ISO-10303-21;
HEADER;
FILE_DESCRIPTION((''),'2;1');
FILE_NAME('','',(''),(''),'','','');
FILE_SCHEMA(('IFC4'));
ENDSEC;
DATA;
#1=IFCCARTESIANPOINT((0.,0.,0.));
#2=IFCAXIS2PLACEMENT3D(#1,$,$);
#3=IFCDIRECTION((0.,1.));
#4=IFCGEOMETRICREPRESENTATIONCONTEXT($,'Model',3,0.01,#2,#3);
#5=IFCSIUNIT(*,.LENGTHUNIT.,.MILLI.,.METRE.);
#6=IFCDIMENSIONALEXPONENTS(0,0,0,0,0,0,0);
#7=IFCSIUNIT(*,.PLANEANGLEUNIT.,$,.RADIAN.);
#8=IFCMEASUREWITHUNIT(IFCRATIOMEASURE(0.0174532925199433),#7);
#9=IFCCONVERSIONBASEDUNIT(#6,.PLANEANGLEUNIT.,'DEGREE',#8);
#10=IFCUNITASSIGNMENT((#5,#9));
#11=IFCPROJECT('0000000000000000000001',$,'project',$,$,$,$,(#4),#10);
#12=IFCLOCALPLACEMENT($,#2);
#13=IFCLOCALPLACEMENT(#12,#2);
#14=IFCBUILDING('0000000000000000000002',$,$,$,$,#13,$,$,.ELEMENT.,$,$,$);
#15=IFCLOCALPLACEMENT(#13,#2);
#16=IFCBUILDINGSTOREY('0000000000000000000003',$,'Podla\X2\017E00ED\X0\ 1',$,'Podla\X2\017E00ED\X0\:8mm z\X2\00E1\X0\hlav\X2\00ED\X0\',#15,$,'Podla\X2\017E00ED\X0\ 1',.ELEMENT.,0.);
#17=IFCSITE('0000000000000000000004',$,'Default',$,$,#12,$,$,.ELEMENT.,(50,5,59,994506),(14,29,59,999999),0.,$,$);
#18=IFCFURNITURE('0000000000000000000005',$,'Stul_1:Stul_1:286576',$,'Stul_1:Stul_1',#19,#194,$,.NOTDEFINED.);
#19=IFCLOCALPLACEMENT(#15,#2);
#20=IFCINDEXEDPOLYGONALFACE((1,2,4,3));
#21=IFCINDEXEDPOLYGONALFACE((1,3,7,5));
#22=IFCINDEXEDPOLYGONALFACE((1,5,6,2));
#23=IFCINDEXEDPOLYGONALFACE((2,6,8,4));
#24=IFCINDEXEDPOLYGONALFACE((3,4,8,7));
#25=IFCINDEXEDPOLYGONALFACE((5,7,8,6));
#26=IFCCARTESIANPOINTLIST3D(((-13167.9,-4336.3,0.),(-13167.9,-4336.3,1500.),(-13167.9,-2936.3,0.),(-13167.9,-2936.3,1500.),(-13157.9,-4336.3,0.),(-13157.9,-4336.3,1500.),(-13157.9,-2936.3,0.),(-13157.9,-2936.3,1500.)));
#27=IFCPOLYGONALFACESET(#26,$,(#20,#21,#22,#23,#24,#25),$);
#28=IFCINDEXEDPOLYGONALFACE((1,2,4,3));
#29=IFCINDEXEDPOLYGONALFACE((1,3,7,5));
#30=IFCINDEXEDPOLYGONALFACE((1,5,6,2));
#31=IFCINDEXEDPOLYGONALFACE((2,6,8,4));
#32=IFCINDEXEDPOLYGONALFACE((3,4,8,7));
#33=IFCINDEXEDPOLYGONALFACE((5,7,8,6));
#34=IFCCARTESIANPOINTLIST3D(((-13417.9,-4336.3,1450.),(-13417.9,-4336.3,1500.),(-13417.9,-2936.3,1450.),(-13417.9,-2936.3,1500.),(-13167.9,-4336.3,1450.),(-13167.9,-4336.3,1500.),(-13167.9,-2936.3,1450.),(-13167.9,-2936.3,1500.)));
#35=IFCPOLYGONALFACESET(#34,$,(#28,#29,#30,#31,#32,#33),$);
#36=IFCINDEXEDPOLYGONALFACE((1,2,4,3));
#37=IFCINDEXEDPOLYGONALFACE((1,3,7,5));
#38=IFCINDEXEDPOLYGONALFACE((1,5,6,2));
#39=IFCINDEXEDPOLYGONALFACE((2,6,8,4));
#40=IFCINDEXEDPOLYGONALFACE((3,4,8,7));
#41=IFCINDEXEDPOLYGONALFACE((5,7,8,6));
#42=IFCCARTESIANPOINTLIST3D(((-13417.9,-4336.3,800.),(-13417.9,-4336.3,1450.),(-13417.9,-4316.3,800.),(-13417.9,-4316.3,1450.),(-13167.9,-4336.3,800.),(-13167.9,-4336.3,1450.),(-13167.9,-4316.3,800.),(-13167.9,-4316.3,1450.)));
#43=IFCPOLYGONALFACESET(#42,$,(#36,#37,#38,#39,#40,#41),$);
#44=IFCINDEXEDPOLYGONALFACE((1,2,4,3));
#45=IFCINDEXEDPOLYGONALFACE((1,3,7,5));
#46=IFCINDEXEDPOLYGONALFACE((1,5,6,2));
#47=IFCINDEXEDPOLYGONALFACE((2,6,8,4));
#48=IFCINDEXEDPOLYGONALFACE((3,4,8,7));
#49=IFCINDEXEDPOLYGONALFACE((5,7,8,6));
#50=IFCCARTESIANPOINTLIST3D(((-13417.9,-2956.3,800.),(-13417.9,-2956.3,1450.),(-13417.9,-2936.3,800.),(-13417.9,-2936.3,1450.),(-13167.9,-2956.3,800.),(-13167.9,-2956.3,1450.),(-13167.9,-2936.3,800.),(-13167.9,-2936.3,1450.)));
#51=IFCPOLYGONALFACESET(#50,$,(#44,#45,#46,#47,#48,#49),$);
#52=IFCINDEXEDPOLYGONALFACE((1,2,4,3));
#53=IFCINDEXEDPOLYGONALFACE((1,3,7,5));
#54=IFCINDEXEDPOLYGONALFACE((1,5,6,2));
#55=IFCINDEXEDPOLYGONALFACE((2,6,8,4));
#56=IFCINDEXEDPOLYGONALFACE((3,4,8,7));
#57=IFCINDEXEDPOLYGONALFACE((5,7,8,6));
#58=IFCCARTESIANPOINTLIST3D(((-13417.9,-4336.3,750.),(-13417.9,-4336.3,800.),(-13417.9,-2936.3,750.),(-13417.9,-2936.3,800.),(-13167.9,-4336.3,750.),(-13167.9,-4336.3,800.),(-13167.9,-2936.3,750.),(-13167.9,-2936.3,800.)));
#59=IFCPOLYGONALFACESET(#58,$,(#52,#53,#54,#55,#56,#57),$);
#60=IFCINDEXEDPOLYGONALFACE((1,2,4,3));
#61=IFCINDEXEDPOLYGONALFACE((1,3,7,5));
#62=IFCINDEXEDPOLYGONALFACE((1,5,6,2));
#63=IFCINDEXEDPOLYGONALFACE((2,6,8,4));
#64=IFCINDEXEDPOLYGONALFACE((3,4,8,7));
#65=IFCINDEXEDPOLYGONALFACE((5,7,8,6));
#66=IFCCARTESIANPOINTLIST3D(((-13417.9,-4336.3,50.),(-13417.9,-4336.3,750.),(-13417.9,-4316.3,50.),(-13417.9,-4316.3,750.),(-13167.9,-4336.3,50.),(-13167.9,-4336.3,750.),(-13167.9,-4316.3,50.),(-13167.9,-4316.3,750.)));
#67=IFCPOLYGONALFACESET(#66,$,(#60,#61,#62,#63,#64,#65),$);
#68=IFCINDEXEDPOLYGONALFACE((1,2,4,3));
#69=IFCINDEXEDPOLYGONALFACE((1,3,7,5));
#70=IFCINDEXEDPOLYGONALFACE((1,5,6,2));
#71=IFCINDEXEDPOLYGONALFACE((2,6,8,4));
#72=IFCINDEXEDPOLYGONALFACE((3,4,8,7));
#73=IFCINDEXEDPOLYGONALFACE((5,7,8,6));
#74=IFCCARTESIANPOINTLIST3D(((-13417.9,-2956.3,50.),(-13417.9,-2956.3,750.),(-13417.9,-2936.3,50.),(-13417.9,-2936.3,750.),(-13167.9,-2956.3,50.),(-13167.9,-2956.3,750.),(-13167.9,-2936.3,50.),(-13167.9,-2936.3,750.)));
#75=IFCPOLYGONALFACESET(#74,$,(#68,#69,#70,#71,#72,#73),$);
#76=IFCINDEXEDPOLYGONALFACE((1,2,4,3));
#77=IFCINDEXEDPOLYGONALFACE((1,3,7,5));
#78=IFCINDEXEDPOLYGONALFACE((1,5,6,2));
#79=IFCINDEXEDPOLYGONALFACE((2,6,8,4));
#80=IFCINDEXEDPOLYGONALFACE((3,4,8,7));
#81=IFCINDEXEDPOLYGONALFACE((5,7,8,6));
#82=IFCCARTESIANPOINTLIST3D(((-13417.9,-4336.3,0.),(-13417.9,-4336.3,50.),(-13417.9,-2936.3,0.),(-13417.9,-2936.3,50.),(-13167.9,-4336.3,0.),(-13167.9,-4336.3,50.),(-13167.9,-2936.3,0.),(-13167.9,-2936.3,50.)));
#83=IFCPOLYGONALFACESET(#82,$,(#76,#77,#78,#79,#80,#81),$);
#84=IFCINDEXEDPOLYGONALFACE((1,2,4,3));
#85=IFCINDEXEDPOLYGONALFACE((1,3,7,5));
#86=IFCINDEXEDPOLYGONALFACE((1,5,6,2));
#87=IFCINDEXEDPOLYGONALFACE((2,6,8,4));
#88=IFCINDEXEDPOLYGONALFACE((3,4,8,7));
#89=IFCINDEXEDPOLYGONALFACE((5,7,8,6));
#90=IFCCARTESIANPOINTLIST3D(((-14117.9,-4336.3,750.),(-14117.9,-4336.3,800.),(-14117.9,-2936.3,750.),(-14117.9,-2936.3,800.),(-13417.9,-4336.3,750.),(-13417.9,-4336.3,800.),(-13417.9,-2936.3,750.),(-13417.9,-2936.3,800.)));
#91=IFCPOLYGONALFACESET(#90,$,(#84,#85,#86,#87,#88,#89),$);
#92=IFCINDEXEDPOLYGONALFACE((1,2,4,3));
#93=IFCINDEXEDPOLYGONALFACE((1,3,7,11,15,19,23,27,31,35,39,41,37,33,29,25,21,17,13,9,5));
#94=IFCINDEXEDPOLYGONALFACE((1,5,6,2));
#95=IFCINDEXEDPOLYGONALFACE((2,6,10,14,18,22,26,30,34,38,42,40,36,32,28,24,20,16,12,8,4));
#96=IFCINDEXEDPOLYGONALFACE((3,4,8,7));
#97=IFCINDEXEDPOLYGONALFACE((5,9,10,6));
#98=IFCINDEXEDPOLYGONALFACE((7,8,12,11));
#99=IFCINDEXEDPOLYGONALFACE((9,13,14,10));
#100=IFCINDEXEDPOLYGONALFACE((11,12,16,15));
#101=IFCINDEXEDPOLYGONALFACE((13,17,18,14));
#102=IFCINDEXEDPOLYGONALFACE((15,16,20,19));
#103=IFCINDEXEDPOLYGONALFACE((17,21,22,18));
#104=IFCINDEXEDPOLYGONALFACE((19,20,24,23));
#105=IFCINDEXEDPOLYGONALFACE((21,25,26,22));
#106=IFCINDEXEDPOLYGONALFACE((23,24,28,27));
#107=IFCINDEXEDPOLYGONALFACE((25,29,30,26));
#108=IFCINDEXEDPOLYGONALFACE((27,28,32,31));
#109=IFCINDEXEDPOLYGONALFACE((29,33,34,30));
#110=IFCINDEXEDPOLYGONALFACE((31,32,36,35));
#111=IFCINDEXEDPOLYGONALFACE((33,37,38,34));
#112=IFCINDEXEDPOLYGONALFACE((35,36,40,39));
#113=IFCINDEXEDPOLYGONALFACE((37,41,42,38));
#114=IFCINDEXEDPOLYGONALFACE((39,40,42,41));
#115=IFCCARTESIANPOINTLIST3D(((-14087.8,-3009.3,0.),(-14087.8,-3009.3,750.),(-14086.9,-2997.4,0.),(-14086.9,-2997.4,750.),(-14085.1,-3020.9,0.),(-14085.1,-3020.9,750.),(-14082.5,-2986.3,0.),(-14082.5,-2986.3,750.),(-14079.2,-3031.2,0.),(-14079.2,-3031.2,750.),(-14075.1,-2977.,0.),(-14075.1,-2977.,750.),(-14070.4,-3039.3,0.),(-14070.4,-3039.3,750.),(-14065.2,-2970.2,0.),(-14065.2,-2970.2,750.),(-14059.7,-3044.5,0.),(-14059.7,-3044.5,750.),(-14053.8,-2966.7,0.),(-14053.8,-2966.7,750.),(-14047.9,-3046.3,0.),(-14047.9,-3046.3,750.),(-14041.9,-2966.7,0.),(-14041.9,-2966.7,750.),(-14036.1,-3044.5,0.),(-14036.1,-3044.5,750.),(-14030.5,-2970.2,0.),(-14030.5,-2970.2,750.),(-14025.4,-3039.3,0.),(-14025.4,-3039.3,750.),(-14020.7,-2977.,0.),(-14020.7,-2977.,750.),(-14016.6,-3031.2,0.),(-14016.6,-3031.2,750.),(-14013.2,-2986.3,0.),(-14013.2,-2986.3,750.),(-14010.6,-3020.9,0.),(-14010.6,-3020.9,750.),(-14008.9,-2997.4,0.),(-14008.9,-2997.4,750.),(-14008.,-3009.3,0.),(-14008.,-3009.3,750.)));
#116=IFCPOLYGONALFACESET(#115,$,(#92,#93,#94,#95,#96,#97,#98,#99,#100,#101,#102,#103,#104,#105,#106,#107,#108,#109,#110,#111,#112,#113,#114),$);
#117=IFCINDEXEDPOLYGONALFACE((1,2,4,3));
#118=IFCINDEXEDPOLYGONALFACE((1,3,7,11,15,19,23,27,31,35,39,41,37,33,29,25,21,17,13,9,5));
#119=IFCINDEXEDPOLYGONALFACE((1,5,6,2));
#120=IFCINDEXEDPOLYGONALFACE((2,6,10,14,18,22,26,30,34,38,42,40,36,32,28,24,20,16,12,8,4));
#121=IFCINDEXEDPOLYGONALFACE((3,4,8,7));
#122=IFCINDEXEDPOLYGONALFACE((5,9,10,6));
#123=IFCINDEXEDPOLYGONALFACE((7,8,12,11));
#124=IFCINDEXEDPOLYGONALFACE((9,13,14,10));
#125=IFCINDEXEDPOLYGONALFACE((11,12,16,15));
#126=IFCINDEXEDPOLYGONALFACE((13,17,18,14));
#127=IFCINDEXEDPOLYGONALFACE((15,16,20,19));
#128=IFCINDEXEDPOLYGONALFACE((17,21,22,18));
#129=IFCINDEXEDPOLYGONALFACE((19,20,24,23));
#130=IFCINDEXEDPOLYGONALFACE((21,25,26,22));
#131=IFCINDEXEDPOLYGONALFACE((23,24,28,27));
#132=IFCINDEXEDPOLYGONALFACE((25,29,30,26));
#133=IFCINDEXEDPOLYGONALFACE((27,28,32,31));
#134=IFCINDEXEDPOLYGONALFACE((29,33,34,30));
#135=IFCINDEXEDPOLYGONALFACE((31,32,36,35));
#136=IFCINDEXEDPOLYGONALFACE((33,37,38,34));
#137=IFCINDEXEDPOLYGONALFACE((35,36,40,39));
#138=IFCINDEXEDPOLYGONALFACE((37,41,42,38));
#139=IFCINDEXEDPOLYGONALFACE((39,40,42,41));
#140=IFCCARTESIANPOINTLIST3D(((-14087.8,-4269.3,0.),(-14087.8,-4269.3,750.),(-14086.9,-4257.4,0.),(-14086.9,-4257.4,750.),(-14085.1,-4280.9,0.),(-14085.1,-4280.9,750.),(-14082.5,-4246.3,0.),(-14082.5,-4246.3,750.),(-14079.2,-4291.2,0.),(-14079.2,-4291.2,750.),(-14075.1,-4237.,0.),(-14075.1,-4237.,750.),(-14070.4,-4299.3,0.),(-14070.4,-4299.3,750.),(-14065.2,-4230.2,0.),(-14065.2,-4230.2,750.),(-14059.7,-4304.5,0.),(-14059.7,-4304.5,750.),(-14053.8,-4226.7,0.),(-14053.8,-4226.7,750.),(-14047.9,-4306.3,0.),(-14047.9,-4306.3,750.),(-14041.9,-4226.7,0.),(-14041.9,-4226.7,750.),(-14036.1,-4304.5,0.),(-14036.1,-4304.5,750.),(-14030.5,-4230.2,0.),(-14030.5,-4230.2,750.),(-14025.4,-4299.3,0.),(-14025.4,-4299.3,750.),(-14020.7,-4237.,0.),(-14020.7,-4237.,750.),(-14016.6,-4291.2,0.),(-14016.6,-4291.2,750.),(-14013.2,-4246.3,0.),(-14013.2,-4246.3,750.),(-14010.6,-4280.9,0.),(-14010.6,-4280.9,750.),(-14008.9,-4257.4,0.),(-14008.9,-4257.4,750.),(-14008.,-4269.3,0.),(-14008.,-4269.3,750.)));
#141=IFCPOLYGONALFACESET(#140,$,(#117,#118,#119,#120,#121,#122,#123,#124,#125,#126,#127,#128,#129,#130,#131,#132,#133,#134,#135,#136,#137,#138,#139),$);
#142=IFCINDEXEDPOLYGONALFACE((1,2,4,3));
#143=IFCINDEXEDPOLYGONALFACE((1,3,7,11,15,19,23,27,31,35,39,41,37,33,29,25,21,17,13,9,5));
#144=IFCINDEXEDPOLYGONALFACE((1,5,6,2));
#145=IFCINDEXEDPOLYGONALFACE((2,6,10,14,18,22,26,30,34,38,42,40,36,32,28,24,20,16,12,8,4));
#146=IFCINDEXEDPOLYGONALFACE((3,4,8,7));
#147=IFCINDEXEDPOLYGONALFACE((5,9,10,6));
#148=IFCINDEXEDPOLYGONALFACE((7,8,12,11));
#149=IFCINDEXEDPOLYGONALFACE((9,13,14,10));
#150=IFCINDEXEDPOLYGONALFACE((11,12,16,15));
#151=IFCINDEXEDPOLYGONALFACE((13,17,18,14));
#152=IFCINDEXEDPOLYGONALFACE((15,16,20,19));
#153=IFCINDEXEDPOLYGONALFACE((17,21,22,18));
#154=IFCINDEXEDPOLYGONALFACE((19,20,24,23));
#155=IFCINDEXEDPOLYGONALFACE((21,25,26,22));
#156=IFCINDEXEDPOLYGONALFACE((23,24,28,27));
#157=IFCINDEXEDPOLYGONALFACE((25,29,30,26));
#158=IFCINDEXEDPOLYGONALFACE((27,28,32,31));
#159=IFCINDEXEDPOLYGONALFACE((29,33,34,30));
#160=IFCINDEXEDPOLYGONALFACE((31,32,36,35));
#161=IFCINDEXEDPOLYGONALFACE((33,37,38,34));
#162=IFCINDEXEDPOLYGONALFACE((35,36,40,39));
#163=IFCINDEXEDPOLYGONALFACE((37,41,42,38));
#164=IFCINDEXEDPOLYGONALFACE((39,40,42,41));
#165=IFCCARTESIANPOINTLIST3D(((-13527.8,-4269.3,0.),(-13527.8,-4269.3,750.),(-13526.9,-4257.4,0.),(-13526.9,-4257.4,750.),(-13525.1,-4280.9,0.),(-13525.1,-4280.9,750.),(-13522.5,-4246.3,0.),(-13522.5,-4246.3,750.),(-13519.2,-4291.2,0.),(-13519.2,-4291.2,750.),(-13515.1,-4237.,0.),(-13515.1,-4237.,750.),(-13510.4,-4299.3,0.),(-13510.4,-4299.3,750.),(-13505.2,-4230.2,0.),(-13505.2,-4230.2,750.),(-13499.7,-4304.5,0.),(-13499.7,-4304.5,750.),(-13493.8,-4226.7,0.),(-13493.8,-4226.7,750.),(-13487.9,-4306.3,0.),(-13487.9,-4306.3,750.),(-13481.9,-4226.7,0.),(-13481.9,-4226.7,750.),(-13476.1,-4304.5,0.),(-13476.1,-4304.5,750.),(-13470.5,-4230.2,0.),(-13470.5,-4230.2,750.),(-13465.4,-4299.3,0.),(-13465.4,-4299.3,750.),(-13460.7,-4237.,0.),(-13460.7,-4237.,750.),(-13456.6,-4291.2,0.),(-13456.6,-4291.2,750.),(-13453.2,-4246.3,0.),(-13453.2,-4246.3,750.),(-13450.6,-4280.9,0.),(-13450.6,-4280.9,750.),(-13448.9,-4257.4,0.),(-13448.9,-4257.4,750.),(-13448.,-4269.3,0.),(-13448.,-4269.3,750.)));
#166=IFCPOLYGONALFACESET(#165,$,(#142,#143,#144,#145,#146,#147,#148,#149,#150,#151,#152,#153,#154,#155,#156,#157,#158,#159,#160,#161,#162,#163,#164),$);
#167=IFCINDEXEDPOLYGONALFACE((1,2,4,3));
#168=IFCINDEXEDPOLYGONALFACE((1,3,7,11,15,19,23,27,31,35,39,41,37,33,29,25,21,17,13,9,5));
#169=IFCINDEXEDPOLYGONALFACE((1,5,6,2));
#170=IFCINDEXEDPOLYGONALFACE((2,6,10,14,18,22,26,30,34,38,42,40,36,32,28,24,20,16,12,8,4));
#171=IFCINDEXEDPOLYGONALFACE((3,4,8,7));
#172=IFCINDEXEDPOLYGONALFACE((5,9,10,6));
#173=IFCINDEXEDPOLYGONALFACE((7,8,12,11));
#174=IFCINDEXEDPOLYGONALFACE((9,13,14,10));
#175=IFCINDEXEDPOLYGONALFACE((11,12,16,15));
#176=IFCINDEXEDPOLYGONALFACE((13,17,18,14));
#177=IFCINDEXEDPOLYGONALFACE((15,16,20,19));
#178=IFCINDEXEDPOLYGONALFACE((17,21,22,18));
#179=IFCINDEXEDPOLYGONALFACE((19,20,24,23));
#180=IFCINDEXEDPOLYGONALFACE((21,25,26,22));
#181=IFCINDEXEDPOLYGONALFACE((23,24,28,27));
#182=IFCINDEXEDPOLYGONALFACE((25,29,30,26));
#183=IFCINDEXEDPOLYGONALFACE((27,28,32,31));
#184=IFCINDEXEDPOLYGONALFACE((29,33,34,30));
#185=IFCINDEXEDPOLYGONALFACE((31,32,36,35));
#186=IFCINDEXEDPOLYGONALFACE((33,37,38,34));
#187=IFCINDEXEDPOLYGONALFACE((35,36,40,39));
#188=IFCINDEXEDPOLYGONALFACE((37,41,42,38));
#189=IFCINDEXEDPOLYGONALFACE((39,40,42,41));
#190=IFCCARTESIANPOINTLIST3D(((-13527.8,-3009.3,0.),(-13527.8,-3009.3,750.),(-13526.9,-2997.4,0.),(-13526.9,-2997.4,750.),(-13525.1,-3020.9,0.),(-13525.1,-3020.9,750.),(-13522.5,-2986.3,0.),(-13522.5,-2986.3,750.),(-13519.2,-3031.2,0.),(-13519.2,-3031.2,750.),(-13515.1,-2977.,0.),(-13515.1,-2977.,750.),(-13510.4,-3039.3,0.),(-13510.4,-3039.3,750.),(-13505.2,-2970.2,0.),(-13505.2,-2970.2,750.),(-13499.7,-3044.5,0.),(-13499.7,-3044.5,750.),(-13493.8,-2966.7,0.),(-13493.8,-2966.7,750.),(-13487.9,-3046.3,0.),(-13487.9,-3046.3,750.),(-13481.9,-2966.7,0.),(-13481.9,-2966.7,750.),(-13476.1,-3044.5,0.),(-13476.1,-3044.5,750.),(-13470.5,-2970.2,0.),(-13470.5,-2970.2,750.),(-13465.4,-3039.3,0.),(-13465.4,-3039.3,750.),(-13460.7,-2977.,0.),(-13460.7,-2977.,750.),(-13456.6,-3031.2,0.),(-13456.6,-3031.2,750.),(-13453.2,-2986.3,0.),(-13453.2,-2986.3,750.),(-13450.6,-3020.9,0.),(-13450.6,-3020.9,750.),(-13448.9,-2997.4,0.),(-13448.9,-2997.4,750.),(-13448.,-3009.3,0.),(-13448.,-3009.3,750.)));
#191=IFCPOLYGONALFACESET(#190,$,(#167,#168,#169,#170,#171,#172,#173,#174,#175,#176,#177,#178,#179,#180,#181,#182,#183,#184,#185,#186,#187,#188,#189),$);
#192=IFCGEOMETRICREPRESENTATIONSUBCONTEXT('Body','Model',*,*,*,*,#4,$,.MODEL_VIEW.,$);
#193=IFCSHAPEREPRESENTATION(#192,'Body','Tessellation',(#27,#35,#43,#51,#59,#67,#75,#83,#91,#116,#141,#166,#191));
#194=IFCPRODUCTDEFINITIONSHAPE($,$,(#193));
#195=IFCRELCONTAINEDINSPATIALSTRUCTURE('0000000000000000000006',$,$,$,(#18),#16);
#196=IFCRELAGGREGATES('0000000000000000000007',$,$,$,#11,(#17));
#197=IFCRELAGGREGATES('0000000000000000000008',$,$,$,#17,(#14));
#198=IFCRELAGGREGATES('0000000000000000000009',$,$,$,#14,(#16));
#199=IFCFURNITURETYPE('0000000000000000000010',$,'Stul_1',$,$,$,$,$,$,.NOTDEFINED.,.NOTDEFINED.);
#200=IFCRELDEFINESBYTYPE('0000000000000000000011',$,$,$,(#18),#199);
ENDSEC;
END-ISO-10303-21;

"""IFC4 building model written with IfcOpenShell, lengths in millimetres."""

from ifc_helpers import new_model, entity, si_unit, converted_unit, direction, frame, frame_2d, origin, origin_2d_with_axis, place, context, subcontext, project, spatial, rectangle, circle, extrude, source, transform, mapped, type_object, type_shapes, element, save


model = new_model("IFC4")

# Units and contexts
model_context = context("Model", 3, precision=0.01, world=origin(), true_north=direction((0.0, 1.0)))
body_context = subcontext(model_context, "Body", "Model", "MODEL_VIEW")
ifc_project = project(units=[si_unit("LENGTHUNIT", "METRE", prefix="MILLI"), converted_unit("PLANEANGLEUNIT", "DEGREE", entity("IfcRatioMeasure", 0.0174532925199433), si_unit("PLANEANGLEUNIT", "RADIAN"), dimensions=[0, 0, 0, 0, 0, 0, 0])], contexts=[model_context])

# Site, building, storey
site_placement = place(None, origin())
site = spatial("IfcSite", under=ifc_project, at=site_placement, Name="Default", CompositionType="ELEMENT", RefLatitude=(50, 5, 59, 994506), RefLongitude=(14, 29, 59, 999999), RefElevation=0.0)
building_placement = place(site_placement, origin())
building = spatial("IfcBuilding", under=site, at=building_placement, CompositionType="ELEMENT")
storey_placement = place(building_placement, origin())
storey = spatial("IfcBuildingStorey", under=building, at=storey_placement, Name="Podlaží 1", ObjectType="Podlaží:8mm záhlaví", LongName="Podlaží 1", CompositionType="ELEMENT", Elevation=0.0)

# Furniture
furniture_type = type_object("IfcFurnitureType", Name="Stul_1", AssemblyPlace="NOTDEFINED", PredefinedType="NOTDEFINED")
shared_shape_1 = source(origin(), body_context, "Body", "SweptSolid", [
    extrude(rectangle(XDim=1400.0, YDim=10.0, at=origin_2d_with_axis()), frame((0.0, 605.0, 0.0), z_axis=(0.0, 0.0, 1.0), x_axis=(-1.0, 0.0, 0.0)), (0.0, 0.0, 1.0), 1500.0),
    extrude(rectangle(XDim=1400.0, YDim=250.0, at=frame_2d((0.0, 0.0), x_axis=(1.0, 0.0))), frame((0.0, 475.0, 1450.0), z_axis=(0.0, 0.0, 1.0), x_axis=(-1.0, 0.0, 0.0)), (0.0, 0.0, 1.0), 50.0),
    extrude(rectangle(XDim=20.0, YDim=250.0, at=origin_2d_with_axis()), frame((690.0, 475.0, 800.0), z_axis=(0.0, 0.0, 1.0), x_axis=(-1.0, 0.0, 0.0)), (0.0, 0.0, 1.0), 650.0),
    extrude(rectangle(XDim=20.0, YDim=250.0, at=frame_2d((0.0, 0.0), x_axis=(1.0, 0.0))), frame((-690.0, 475.0, 800.0), z_axis=(0.0, 0.0, 1.0), x_axis=(-1.0, 0.0, 0.0)), (0.0, 0.0, 1.0), 650.0),
    extrude(rectangle(XDim=1400.0, YDim=250.0, at=origin_2d_with_axis()), frame((0.0, 475.0, 750.0), z_axis=(0.0, 0.0, 1.0), x_axis=(-1.0, 0.0, 0.0)), (0.0, 0.0, 1.0), 50.0),
    extrude(rectangle(XDim=20.0, YDim=250.0, at=origin_2d_with_axis()), frame((690.0, 475.0, 50.0), z_axis=(0.0, 0.0, 1.0), x_axis=(-1.0, 0.0, 0.0)), (0.0, 0.0, 1.0), 700.0),
    extrude(rectangle(XDim=20.0, YDim=250.0, at=frame_2d((0.0, 0.0), x_axis=(1.0, 0.0))), frame((-690.0, 475.0, 50.0), z_axis=(0.0, 0.0, 1.0), x_axis=(-1.0, 0.0, 0.0)), (0.0, 0.0, 1.0), 700.0),
    extrude(rectangle(XDim=1400.0, YDim=250.0, at=origin_2d_with_axis()), frame((0.0, 475.0, 0.0), z_axis=(0.0, 0.0, 1.0), x_axis=(-1.0, 0.0, 0.0)), (0.0, 0.0, 1.0), 50.0),
    extrude(rectangle(XDim=1400.0, YDim=700.0, at=origin_2d_with_axis()), frame((0.0, 0.0, 750.0), z_axis=(0.0, 0.0, 1.0), x_axis=(-1.0, 0.0, 0.0)), (0.0, 0.0, 1.0), 50.0),
    extrude(circle(Radius=40.0, at=frame_2d((0.0, 0.0), x_axis=(1.0, 0.0))), frame((-630.0, -280.0, 0.0)), (0.0, 0.0, 1.0), 750.0),
    extrude(circle(Radius=40.0, at=frame_2d((0.0, 0.0), x_axis=(1.0, 0.0))), frame((630.0, -280.0, 0.0)), (0.0, 0.0, 1.0), 750.0),
    extrude(circle(Radius=40.0, at=frame_2d((0.0, 0.0), x_axis=(1.0, 0.0))), frame((630.0, 280.0, 0.0)), (0.0, 0.0, 1.0), 750.0),
    extrude(circle(Radius=40.0, at=frame_2d((0.0, 0.0), x_axis=(1.0, 0.0))), frame((-630.0, 280.0, 0.0)), (0.0, 0.0, 1.0), 750.0),
])
type_shapes(furniture_type, [shared_shape_1])
for number, where, z_axis, x_axis, name in (
    (1, (-13767.9, -3636.3, 0.0), (0.0, 0.0, 1.0), (0.0, -1.0, 0.0), "Stul_1:Stul_1:286576"),
):
    element("IfcFurniture", number, at=place(storey_placement, frame(where, z_axis=z_axis, x_axis=x_axis)), inside=storey, type_object=furniture_type, Name=name, ObjectType="Stul_1:Stul_1", PredefinedType="NOTDEFINED", context=body_context, shape_type="MappedRepresentation", body=[
        mapped(shared_shape_1, transform((0.0, 0.0, 0.0), scale=1.0)),
    ])

save(model, "model.ifc")
